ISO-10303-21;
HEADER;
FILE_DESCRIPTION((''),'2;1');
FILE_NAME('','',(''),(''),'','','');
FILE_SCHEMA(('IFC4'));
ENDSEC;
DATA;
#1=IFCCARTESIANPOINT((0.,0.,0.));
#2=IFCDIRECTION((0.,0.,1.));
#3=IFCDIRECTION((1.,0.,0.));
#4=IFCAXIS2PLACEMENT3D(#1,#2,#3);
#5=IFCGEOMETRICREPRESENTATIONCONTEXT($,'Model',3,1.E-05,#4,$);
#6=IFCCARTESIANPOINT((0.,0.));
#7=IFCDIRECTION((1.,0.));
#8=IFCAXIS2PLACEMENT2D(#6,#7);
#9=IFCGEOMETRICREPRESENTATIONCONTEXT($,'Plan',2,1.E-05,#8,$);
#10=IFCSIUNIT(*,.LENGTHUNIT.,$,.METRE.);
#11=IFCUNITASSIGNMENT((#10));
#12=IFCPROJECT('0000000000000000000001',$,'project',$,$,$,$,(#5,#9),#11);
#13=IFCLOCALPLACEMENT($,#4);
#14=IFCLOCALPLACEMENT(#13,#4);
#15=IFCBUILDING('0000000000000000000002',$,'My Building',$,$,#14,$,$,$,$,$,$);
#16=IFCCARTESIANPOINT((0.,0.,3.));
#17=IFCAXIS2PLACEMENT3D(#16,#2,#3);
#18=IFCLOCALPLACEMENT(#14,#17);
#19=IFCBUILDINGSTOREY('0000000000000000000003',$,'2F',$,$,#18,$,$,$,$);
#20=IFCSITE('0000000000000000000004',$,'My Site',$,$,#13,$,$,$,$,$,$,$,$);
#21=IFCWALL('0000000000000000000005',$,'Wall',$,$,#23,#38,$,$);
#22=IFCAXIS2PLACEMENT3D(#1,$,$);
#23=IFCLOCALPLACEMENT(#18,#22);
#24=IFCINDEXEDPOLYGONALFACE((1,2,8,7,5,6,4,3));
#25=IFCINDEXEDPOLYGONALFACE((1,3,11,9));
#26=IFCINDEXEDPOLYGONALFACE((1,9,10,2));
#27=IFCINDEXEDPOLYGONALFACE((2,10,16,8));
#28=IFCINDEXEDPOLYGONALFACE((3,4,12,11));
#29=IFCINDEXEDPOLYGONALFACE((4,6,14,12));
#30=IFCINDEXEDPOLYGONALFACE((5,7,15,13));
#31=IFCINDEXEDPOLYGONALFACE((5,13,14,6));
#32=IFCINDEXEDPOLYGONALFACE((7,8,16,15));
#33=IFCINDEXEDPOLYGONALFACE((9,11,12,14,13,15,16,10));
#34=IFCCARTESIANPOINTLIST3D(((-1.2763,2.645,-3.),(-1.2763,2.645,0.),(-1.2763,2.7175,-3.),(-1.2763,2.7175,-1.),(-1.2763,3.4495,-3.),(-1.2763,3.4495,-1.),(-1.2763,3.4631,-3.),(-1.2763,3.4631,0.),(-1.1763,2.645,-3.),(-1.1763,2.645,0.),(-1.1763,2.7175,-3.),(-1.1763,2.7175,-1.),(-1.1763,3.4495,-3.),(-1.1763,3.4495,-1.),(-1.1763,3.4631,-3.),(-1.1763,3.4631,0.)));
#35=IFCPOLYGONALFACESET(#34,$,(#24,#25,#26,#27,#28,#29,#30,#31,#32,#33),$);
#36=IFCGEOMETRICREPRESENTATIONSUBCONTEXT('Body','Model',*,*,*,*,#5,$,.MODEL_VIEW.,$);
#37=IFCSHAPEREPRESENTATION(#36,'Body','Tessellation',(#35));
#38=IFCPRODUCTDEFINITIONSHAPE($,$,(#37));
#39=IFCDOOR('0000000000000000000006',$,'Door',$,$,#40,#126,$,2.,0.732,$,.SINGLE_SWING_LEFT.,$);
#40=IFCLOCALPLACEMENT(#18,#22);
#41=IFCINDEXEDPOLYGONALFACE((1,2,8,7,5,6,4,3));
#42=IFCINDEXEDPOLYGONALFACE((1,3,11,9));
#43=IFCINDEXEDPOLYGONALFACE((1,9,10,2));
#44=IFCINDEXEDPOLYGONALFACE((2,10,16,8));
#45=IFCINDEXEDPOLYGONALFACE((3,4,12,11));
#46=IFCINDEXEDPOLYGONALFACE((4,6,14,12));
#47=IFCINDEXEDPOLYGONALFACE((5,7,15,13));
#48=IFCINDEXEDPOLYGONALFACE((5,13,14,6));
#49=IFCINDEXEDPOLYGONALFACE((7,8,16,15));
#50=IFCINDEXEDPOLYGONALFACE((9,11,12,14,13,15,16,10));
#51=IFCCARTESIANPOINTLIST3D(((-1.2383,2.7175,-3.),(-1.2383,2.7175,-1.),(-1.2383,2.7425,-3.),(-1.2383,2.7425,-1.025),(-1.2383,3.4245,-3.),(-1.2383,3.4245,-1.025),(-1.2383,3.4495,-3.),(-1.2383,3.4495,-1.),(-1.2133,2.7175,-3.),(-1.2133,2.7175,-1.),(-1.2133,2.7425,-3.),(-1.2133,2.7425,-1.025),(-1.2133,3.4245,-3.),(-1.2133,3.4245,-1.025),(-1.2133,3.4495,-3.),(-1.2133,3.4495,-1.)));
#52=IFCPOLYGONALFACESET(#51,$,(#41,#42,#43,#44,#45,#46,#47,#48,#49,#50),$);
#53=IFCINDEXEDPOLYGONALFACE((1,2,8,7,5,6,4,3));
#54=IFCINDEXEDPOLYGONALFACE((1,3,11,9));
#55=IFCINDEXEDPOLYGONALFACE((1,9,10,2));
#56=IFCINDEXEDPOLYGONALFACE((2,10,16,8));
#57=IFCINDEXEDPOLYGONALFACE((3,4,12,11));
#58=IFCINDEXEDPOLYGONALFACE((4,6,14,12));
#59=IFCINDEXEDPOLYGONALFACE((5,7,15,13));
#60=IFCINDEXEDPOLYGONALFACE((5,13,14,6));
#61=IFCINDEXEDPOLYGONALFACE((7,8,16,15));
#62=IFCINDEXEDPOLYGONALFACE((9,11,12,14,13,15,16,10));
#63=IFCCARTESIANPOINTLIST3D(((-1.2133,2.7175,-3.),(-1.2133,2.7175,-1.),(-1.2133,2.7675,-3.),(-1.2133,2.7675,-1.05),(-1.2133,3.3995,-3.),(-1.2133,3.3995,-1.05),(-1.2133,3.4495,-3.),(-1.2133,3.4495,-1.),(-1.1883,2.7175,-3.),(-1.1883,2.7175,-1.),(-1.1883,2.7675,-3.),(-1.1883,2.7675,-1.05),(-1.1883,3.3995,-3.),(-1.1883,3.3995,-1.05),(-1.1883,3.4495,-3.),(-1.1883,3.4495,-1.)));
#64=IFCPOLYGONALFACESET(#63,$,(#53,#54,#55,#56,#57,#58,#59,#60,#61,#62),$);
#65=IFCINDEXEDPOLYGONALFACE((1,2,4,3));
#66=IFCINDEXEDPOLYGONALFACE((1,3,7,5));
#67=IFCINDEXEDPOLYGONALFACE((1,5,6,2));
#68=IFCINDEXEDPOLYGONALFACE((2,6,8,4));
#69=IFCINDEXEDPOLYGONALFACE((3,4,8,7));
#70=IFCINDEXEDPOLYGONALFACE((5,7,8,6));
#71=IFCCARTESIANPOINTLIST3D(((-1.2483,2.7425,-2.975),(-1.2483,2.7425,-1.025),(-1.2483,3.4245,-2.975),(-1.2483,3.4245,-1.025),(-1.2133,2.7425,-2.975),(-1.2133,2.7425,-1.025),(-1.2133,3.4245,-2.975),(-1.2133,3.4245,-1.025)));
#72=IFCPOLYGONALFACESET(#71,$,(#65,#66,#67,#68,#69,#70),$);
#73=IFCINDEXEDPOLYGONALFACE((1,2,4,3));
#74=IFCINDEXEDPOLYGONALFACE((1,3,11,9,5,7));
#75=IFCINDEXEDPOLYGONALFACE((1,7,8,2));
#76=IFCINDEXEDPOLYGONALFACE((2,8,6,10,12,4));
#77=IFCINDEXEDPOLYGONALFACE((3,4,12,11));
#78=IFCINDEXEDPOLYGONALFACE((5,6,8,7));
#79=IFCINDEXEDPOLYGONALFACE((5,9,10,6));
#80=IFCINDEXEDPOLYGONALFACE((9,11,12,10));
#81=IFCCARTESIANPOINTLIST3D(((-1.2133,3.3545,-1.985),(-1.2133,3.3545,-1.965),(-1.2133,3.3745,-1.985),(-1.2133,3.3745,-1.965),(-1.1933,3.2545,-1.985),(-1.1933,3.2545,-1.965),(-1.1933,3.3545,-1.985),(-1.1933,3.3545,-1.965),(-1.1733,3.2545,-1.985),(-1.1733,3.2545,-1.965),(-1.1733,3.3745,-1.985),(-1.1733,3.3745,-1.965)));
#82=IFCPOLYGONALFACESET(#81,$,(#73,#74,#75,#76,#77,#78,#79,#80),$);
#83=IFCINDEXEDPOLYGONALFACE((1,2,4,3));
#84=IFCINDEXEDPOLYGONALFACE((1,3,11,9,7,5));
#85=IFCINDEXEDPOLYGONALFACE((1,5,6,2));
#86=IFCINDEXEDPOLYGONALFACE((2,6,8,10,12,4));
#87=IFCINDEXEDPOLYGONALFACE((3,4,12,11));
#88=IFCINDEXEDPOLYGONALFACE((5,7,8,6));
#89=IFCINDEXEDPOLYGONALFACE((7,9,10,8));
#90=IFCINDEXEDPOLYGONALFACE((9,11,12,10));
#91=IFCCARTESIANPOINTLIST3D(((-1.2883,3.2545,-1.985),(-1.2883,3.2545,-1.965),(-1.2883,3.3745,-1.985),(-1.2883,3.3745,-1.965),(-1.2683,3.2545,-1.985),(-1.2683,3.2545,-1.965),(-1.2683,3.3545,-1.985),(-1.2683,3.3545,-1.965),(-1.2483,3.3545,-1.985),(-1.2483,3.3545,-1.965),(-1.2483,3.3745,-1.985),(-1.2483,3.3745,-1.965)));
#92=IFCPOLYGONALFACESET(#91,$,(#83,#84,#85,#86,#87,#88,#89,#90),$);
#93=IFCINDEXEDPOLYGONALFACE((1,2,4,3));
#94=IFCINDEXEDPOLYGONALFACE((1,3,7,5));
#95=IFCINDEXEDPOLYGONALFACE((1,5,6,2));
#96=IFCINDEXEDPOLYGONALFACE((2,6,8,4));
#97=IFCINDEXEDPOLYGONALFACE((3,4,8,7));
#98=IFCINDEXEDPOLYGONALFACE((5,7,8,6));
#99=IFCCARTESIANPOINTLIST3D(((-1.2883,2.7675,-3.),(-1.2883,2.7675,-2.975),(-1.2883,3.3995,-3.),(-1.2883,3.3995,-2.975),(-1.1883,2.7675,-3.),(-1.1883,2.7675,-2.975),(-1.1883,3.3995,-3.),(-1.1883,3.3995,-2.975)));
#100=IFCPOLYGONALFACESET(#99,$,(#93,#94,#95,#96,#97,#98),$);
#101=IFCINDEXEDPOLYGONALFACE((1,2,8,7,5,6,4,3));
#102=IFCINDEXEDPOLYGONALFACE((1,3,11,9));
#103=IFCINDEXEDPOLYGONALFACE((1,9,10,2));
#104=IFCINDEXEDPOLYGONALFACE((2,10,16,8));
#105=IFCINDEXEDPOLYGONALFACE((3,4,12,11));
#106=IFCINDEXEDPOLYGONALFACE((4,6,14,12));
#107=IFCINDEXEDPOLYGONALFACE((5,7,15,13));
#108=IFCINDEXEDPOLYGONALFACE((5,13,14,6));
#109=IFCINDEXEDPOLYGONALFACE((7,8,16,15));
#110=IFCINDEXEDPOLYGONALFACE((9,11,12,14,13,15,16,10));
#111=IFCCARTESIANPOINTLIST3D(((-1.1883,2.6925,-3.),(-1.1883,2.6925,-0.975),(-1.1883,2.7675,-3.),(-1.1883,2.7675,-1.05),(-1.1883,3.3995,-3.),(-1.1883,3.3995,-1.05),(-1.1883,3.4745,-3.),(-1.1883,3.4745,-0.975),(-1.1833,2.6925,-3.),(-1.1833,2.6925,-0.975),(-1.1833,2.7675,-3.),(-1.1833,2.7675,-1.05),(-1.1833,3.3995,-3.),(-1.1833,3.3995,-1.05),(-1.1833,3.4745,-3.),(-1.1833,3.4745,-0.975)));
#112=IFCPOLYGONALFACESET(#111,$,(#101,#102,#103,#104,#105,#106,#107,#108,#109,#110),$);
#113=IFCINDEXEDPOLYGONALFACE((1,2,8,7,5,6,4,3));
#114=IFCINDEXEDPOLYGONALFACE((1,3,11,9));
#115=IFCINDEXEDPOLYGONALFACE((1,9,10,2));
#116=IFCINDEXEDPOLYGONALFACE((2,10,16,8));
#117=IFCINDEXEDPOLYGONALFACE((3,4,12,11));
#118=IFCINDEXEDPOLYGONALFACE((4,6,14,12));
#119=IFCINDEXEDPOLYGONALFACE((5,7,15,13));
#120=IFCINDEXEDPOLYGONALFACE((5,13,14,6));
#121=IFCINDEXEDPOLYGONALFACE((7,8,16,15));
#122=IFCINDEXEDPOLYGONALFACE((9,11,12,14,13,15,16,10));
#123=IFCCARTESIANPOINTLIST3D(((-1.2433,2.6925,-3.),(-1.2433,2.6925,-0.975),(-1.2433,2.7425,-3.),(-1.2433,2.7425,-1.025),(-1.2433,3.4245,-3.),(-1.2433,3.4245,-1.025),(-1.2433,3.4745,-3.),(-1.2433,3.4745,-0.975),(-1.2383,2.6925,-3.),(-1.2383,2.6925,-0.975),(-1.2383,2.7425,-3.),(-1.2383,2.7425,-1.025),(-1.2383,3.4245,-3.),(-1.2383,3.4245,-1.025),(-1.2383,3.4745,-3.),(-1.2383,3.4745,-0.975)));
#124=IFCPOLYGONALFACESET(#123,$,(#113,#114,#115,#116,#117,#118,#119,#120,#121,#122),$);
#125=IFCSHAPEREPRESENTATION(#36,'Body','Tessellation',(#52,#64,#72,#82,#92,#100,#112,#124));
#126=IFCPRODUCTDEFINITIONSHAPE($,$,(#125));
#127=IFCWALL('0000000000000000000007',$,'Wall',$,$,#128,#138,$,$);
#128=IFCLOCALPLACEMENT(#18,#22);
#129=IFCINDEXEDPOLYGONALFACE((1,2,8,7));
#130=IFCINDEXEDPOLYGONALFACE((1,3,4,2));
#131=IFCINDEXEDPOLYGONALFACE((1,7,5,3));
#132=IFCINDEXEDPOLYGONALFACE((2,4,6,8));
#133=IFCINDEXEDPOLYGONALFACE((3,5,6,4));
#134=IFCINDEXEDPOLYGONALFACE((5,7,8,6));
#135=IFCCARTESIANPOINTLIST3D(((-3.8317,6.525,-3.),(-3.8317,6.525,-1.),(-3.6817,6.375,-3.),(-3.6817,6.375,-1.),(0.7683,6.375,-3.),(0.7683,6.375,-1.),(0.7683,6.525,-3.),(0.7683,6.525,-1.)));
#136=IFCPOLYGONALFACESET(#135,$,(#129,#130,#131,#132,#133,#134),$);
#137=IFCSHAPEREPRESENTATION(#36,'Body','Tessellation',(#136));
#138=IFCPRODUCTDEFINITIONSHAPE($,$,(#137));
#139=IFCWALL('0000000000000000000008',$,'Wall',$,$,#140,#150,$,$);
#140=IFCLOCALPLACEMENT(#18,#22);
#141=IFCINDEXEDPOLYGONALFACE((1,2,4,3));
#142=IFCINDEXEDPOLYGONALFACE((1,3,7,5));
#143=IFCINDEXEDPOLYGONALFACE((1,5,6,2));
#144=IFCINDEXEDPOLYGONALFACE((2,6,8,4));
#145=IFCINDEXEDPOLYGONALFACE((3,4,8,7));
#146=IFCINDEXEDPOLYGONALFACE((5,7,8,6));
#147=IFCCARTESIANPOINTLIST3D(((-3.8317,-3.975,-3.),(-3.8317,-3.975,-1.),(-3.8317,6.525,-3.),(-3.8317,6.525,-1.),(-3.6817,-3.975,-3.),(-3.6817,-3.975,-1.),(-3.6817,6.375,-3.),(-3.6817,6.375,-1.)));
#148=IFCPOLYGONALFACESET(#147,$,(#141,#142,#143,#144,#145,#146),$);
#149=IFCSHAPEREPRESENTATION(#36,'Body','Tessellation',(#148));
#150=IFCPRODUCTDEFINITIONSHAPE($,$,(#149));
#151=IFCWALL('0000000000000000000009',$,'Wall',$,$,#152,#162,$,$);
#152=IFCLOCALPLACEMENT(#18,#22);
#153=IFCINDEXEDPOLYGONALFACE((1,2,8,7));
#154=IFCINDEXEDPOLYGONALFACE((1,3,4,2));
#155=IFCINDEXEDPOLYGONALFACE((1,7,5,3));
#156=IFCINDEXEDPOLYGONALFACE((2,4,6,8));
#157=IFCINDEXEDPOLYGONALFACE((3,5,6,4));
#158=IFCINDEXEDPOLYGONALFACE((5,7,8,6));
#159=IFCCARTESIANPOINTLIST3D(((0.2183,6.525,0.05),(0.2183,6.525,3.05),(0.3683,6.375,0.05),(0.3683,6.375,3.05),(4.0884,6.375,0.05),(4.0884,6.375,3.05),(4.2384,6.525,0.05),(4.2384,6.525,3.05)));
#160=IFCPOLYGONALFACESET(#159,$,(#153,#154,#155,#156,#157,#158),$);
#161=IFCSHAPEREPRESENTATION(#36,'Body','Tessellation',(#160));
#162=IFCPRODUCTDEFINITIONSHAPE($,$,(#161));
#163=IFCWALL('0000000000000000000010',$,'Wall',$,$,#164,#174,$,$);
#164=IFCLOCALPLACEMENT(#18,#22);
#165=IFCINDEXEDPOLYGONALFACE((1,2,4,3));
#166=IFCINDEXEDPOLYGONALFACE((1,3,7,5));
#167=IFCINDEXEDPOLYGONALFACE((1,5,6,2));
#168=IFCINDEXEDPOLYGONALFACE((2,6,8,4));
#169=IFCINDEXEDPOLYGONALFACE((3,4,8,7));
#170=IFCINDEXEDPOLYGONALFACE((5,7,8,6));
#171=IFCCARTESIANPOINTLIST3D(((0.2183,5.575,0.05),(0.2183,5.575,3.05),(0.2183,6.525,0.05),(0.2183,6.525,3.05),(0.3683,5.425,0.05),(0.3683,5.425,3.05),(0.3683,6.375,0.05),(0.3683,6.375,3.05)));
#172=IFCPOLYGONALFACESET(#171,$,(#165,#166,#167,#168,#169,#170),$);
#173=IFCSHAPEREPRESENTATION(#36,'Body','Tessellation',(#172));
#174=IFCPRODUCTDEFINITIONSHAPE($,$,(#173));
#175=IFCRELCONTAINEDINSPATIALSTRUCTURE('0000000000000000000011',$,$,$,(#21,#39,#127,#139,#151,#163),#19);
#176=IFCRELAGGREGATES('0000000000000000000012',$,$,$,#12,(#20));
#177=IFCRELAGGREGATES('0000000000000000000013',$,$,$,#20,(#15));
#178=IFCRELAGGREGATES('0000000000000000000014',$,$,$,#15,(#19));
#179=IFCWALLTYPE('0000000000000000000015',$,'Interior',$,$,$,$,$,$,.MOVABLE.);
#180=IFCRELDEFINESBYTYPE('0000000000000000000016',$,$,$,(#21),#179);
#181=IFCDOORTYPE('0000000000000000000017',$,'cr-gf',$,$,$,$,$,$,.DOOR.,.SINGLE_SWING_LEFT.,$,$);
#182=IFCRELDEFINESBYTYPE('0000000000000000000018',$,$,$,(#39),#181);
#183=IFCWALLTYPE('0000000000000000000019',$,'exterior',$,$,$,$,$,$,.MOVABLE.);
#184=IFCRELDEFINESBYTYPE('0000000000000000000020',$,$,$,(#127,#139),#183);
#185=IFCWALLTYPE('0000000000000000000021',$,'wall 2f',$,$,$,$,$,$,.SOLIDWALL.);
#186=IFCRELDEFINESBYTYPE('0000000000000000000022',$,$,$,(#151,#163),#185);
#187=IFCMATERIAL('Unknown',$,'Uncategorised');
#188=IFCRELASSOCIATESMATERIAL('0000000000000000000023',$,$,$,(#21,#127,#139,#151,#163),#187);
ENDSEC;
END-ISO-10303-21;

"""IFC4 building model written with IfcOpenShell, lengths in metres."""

from ifc_helpers import new_model, entity, si_unit, frame, origin_with_axes, origin_2d_with_axis, place, context, subcontext, project, spatial, line, indexed_curve, outline, extrude, shape, source, transform, mapped, material, type_object, type_shapes, element, fill, save


model = new_model("IFC4")

# Units and contexts
model_context = context("Model", 3, precision=1e-05, world=origin_with_axes())
plan_context = context("Plan", 2, precision=1e-05, world=origin_2d_with_axis())
body_context_1 = subcontext(model_context, "Body", "Model", "MODEL_VIEW")
body_context_2 = subcontext(plan_context, "Body", "Plan", "PLAN_VIEW")
ifc_project = project(units=[si_unit("LENGTHUNIT", "METRE")], contexts=[model_context, plan_context])

# Site, building, storey
site_placement = place(None, origin_with_axes())
site = spatial("IfcSite", under=ifc_project, at=site_placement, Name="My Site")
building_placement = place(site_placement, origin_with_axes())
building = spatial("IfcBuilding", under=site, at=building_placement, Name="My Building")
storey_placement = place(building_placement, frame((0.0, 0.0, 3.0), z_axis=(0.0, 0.0, 1.0), x_axis=(1.0, 0.0, 0.0)))
storey = spatial("IfcBuildingStorey", under=building, at=storey_placement, Name="2F")

# Shared definitions
ifc_material = material(Name="Unknown", Category="Uncategorised")

# Wall, opening, door
wall_type_1 = type_object("IfcWallType", Name="Interior", PredefinedType="MOVABLE")
wall_1_placement = place(storey_placement, frame((-1.2763, 3.4631, -3.0), z_axis=(0.0, 0.0, 1.0), x_axis=(0.0, -1.0, 0.0)))
wall_1 = element("IfcWall", 1, at=wall_1_placement, inside=storey, type_object=wall_type_1, material=ifc_material, Name="Wall", context=body_context_1, shape_type="SweptSolid", body=[
    extrude(outline(indexed_curve([(0.0, 0.0), (0.0, 0.1), (0.8182, 0.1), (0.8182, 0.0)], segments=[line(1, 2, 3, 4, 1)])), origin_with_axes(), (0.0, 0.0, 1.0), 3.0),
])
shared_shape_1 = source(origin_with_axes(), body_context_1, "Body", "SweptSolid", [
    extrude(outline(indexed_curve([(0.0, 0.0), (0.732, 0.0), (0.732, 2.0), (0.0, 2.0)], segments=[line(1, 2, 3, 4, 1)])), frame((0.0, -0.6, 0.0), z_axis=(0.0, -1.0, 0.0), x_axis=(1.0, 0.0, 0.0)), (0.0, 0.0, -1.0), 1.2),
])
opening_1_placement = place(wall_1_placement, frame((0.7456, 0.088, 0.0), z_axis=(0.0, 0.0, 1.0), x_axis=(-1.0, 0.0, 0.0)))
opening_1 = element("IfcOpeningElement", 2, at=opening_1_placement, cuts=wall_1, PredefinedType="OPENING", context=body_context_1, shape_type="MappedRepresentation", body=[
    mapped(shared_shape_1, transform((0.0, 0.0, 0.0), x_axis=(1.0, 0.0, 0.0), y_axis=(0.0, 1.0, 0.0), z_axis=(0.0, 0.0, 1.0), scale=1.0)),
])
door_type_1 = type_object("IfcDoorType", Name="cr-gf", OperationType="SINGLE_SWING_LEFT", PredefinedType="DOOR")
shared_shape_2 = source(origin_with_axes(), body_context_1, "Body", "SweptSolid", [
    extrude(outline(indexed_curve([(0.0, 0.0), (0.0, 2.0), (0.732, 2.0), (0.732, 0.0), (0.707, 0.0), (0.707, 1.975), (0.025, 1.975), (0.025, 0.0)], segments=[line(1, 2, 3, 4, 5, 6, 7, 8, 1)])), frame((0.0, 0.025, 0.0), z_axis=(0.0, -1.0, 0.0), x_axis=(1.0, 0.0, 0.0)), (0.0, 0.0, -1.0), 0.025),
    extrude(outline(indexed_curve([(0.0, 0.0), (0.0, 2.0), (0.732, 2.0), (0.732, 0.0), (0.682, 0.0), (0.682, 1.95), (0.05, 1.95), (0.05, 0.0)], segments=[line(1, 2, 3, 4, 5, 6, 7, 8, 1)])), frame((0.0, 0.0, 0.0), z_axis=(0.0, -1.0, 0.0), x_axis=(1.0, 0.0, 0.0)), (0.0, 0.0, -1.0), 0.025),
    extrude(outline(indexed_curve([(0.0, 0.0), (0.682, 0.0), (0.682, 0.035), (0.0, 0.035)], segments=[line(1, 2, 3, 4, 1)])), frame((0.025, 0.025, 0.025), z_axis=(0.0, 0.0, 1.0), x_axis=(1.0, 0.0, 0.0)), (0.0, 0.0, 1.0), 1.95),
    extrude(outline(indexed_curve([(0.0, 0.0), (0.0, -0.04), (-0.12, -0.04), (-0.12, -0.02), (-0.02, -0.02), (-0.02, 0.0)], segments=[line(1, 2, 3, 4, 5, 6, 1)])), frame((0.657, 0.025, 1.015), z_axis=(0.0, 0.0, 1.0), x_axis=(1.0, 0.0, 0.0)), (0.0, 0.0, 1.0), 0.02),
    extrude(outline(indexed_curve([(0.0, 0.0), (0.0, 0.04), (-0.12, 0.04), (-0.12, 0.02), (-0.02, 0.02), (-0.02, 0.0)], segments=[line(1, 2, 3, 4, 5, 6, 1)])), frame((0.657, 0.06, 1.015), z_axis=(0.0, 0.0, 1.0), x_axis=(1.0, 0.0, 0.0)), (0.0, 0.0, 1.0), 0.02),
    extrude(outline(indexed_curve([(0.0, 0.0), (0.632, 0.0), (0.632, 0.1), (0.0, 0.1)], segments=[line(1, 2, 3, 4, 1)])), frame((0.05, 0.0, 0.0), z_axis=(0.0, 0.0, 1.0), x_axis=(1.0, 0.0, 0.0)), (0.0, 0.0, 1.0), 0.025),
    extrude(outline(indexed_curve([(0.0, 0.0), (0.0, 2.025), (0.782, 2.025), (0.782, 0.0), (0.707, 0.0), (0.707, 1.95), (0.075, 1.95), (0.075, 0.0)], segments=[line(1, 2, 3, 4, 5, 6, 7, 8, 1)])), frame((-0.025, -0.005, 0.0), z_axis=(0.0, -1.0, 0.0), x_axis=(1.0, 0.0, 0.0)), (0.0, 0.0, -1.0), 0.005),
    extrude(outline(indexed_curve([(0.0, 0.0), (0.0, 2.025), (0.782, 2.025), (0.782, 0.0), (0.732, 0.0), (0.732, 1.975), (0.05, 1.975), (0.05, 0.0)], segments=[line(1, 2, 3, 4, 5, 6, 7, 8, 1)])), frame((-0.025, 0.05, 0.0), z_axis=(0.0, -1.0, 0.0), x_axis=(1.0, 0.0, 0.0)), (0.0, 0.0, -1.0), 0.005),
])
shared_shape_3 = source(origin_with_axes(), body_context_2, "Body", "Curve2D", [
    entity("IfcIndexedPolyCurve", entity("IfcCartesianPointList2D", [[0.0, 0.0], [0.0, 0.05], [0.025, 0.05], [0.025, 0.025], [0.05, 0.025], [0.05, 0.0]]), [entity("IfcLineIndex", [1, 2, 3, 4, 5, 6, 1])]),
    entity("IfcIndexedPolyCurve", entity("IfcCartesianPointList2D", [[0.732, 0.0], [0.732, 0.05], [0.707, 0.05], [0.707, 0.025], [0.682, 0.025], [0.682, 0.0]]), [entity("IfcLineIndex", [1, 2, 3, 4, 5, 6, 1])]),
    entity("IfcTrimmedCurve", entity("IfcEllipse", entity("IfcAxis2Placement2D", entity("IfcCartesianPoint", [0.06, 0.05]), entity("IfcDirection", [1.0, 0.0])), 0.647, 0.682), [entity("IfcCartesianPoint", [0.707, 0.05])], [entity("IfcCartesianPoint", [0.06, 0.732])], True, "CARTESIAN"),
    entity("IfcIndexedPolyCurve", entity("IfcCartesianPointList2D", [[0.025, 0.05], [0.06, 0.05], [0.06, 0.732], [0.025, 0.732]]), [entity("IfcLineIndex", [1, 2, 3, 4, 1])]),
])
type_shapes(door_type_1, [shared_shape_2, shared_shape_3])
door_1_placement = place(opening_1_placement, frame((0.0, 0.0, 0.0), z_axis=(0.0, 0.0, 1.0), x_axis=(1.0, 0.0, 0.0)))
door_1 = element("IfcDoor", 3, at=door_1_placement, inside=storey, type_object=door_type_1, Name="Door", OperationType="SINGLE_SWING_LEFT", OverallHeight=2.0, OverallWidth=0.732, shapes=[
    shape(body_context_1, "Body", "MappedRepresentation", [mapped(shared_shape_2, transform((0.0, 0.0, 0.0), x_axis=(1.0, 0.0, 0.0), y_axis=(0.0, 1.0, 0.0), z_axis=(0.0, 0.0, 1.0), scale=1.0))]),
    shape(body_context_2, "Body", "MappedRepresentation", [mapped(shared_shape_3, transform((0.0, 0.0, 0.0), x_axis=(1.0, 0.0, 0.0), y_axis=(0.0, 1.0, 0.0), z_axis=(0.0, 0.0, 1.0), scale=1.0))]),
])
fill(opening_1, door_1)

# Walls
wall_type_2 = type_object("IfcWallType", Name="exterior", PredefinedType="MOVABLE")
wall_2_placement = place(storey_placement, frame((0.7683, 6.525, -3.0), z_axis=(0.0, 0.0, 1.0), x_axis=(-1.0, 0.0, 0.0)))
element("IfcWall", 4, at=wall_2_placement, inside=storey, type_object=wall_type_2, material=ifc_material, Name="Wall", context=body_context_1, shape_type="SweptSolid", body=[
    extrude(outline(indexed_curve([(0.0, 0.0), (0.0, 0.15), (4.45, 0.15), (4.6, 0.0)], segments=[line(1, 2, 3, 4, 1)])), origin_with_axes(), (0.0, 0.0, 1.0), 2.0),
])
wall_3_placement = place(storey_placement, frame((-3.8317, 6.525, -3.0), z_axis=(0.0, 0.0, 1.0), x_axis=(0.0, -1.0, 0.0)))
element("IfcWall", 5, at=wall_3_placement, inside=storey, type_object=wall_type_2, material=ifc_material, Name="Wall", context=body_context_1, shape_type="SweptSolid", body=[
    extrude(outline(indexed_curve([(0.0, 0.0), (0.15, 0.15), (10.5, 0.15), (10.5, 0.0)], segments=[line(1, 2, 3, 4, 1)])), origin_with_axes(), (0.0, 0.0, 1.0), 2.0),
])
wall_type_3 = type_object("IfcWallType", Name="wall 2f", PredefinedType="SOLIDWALL")
wall_4_placement = place(storey_placement, frame((4.2384, 6.525, 0.05), z_axis=(0.0, 0.0, 1.0), x_axis=(-1.0, 0.0, 0.0)))
element("IfcWall", 6, at=wall_4_placement, inside=storey, type_object=wall_type_3, material=ifc_material, Name="Wall", context=body_context_1, shape_type="SweptSolid", body=[
    extrude(outline(indexed_curve([(0.0, 0.0), (0.15, 0.15), (3.87, 0.15), (4.02, 0.0)], segments=[line(1, 2, 3, 4, 1)])), origin_with_axes(), (0.0, 0.0, 1.0), 3.0),
])
wall_5_placement = place(storey_placement, frame((0.2183, 6.525, 0.05), z_axis=(0.0, 0.0, 1.0), x_axis=(0.0, -1.0, 0.0)))
element("IfcWall", 7, at=wall_5_placement, inside=storey, type_object=wall_type_3, material=ifc_material, Name="Wall", context=body_context_1, shape_type="SweptSolid", body=[
    extrude(outline(indexed_curve([(0.0, 0.0), (0.15, 0.15), (1.1, 0.15), (0.95, 0.0)], segments=[line(1, 2, 3, 4, 1)])), origin_with_axes(), (0.0, 0.0, 1.0), 3.0),
])

save(model, "model.ifc")
